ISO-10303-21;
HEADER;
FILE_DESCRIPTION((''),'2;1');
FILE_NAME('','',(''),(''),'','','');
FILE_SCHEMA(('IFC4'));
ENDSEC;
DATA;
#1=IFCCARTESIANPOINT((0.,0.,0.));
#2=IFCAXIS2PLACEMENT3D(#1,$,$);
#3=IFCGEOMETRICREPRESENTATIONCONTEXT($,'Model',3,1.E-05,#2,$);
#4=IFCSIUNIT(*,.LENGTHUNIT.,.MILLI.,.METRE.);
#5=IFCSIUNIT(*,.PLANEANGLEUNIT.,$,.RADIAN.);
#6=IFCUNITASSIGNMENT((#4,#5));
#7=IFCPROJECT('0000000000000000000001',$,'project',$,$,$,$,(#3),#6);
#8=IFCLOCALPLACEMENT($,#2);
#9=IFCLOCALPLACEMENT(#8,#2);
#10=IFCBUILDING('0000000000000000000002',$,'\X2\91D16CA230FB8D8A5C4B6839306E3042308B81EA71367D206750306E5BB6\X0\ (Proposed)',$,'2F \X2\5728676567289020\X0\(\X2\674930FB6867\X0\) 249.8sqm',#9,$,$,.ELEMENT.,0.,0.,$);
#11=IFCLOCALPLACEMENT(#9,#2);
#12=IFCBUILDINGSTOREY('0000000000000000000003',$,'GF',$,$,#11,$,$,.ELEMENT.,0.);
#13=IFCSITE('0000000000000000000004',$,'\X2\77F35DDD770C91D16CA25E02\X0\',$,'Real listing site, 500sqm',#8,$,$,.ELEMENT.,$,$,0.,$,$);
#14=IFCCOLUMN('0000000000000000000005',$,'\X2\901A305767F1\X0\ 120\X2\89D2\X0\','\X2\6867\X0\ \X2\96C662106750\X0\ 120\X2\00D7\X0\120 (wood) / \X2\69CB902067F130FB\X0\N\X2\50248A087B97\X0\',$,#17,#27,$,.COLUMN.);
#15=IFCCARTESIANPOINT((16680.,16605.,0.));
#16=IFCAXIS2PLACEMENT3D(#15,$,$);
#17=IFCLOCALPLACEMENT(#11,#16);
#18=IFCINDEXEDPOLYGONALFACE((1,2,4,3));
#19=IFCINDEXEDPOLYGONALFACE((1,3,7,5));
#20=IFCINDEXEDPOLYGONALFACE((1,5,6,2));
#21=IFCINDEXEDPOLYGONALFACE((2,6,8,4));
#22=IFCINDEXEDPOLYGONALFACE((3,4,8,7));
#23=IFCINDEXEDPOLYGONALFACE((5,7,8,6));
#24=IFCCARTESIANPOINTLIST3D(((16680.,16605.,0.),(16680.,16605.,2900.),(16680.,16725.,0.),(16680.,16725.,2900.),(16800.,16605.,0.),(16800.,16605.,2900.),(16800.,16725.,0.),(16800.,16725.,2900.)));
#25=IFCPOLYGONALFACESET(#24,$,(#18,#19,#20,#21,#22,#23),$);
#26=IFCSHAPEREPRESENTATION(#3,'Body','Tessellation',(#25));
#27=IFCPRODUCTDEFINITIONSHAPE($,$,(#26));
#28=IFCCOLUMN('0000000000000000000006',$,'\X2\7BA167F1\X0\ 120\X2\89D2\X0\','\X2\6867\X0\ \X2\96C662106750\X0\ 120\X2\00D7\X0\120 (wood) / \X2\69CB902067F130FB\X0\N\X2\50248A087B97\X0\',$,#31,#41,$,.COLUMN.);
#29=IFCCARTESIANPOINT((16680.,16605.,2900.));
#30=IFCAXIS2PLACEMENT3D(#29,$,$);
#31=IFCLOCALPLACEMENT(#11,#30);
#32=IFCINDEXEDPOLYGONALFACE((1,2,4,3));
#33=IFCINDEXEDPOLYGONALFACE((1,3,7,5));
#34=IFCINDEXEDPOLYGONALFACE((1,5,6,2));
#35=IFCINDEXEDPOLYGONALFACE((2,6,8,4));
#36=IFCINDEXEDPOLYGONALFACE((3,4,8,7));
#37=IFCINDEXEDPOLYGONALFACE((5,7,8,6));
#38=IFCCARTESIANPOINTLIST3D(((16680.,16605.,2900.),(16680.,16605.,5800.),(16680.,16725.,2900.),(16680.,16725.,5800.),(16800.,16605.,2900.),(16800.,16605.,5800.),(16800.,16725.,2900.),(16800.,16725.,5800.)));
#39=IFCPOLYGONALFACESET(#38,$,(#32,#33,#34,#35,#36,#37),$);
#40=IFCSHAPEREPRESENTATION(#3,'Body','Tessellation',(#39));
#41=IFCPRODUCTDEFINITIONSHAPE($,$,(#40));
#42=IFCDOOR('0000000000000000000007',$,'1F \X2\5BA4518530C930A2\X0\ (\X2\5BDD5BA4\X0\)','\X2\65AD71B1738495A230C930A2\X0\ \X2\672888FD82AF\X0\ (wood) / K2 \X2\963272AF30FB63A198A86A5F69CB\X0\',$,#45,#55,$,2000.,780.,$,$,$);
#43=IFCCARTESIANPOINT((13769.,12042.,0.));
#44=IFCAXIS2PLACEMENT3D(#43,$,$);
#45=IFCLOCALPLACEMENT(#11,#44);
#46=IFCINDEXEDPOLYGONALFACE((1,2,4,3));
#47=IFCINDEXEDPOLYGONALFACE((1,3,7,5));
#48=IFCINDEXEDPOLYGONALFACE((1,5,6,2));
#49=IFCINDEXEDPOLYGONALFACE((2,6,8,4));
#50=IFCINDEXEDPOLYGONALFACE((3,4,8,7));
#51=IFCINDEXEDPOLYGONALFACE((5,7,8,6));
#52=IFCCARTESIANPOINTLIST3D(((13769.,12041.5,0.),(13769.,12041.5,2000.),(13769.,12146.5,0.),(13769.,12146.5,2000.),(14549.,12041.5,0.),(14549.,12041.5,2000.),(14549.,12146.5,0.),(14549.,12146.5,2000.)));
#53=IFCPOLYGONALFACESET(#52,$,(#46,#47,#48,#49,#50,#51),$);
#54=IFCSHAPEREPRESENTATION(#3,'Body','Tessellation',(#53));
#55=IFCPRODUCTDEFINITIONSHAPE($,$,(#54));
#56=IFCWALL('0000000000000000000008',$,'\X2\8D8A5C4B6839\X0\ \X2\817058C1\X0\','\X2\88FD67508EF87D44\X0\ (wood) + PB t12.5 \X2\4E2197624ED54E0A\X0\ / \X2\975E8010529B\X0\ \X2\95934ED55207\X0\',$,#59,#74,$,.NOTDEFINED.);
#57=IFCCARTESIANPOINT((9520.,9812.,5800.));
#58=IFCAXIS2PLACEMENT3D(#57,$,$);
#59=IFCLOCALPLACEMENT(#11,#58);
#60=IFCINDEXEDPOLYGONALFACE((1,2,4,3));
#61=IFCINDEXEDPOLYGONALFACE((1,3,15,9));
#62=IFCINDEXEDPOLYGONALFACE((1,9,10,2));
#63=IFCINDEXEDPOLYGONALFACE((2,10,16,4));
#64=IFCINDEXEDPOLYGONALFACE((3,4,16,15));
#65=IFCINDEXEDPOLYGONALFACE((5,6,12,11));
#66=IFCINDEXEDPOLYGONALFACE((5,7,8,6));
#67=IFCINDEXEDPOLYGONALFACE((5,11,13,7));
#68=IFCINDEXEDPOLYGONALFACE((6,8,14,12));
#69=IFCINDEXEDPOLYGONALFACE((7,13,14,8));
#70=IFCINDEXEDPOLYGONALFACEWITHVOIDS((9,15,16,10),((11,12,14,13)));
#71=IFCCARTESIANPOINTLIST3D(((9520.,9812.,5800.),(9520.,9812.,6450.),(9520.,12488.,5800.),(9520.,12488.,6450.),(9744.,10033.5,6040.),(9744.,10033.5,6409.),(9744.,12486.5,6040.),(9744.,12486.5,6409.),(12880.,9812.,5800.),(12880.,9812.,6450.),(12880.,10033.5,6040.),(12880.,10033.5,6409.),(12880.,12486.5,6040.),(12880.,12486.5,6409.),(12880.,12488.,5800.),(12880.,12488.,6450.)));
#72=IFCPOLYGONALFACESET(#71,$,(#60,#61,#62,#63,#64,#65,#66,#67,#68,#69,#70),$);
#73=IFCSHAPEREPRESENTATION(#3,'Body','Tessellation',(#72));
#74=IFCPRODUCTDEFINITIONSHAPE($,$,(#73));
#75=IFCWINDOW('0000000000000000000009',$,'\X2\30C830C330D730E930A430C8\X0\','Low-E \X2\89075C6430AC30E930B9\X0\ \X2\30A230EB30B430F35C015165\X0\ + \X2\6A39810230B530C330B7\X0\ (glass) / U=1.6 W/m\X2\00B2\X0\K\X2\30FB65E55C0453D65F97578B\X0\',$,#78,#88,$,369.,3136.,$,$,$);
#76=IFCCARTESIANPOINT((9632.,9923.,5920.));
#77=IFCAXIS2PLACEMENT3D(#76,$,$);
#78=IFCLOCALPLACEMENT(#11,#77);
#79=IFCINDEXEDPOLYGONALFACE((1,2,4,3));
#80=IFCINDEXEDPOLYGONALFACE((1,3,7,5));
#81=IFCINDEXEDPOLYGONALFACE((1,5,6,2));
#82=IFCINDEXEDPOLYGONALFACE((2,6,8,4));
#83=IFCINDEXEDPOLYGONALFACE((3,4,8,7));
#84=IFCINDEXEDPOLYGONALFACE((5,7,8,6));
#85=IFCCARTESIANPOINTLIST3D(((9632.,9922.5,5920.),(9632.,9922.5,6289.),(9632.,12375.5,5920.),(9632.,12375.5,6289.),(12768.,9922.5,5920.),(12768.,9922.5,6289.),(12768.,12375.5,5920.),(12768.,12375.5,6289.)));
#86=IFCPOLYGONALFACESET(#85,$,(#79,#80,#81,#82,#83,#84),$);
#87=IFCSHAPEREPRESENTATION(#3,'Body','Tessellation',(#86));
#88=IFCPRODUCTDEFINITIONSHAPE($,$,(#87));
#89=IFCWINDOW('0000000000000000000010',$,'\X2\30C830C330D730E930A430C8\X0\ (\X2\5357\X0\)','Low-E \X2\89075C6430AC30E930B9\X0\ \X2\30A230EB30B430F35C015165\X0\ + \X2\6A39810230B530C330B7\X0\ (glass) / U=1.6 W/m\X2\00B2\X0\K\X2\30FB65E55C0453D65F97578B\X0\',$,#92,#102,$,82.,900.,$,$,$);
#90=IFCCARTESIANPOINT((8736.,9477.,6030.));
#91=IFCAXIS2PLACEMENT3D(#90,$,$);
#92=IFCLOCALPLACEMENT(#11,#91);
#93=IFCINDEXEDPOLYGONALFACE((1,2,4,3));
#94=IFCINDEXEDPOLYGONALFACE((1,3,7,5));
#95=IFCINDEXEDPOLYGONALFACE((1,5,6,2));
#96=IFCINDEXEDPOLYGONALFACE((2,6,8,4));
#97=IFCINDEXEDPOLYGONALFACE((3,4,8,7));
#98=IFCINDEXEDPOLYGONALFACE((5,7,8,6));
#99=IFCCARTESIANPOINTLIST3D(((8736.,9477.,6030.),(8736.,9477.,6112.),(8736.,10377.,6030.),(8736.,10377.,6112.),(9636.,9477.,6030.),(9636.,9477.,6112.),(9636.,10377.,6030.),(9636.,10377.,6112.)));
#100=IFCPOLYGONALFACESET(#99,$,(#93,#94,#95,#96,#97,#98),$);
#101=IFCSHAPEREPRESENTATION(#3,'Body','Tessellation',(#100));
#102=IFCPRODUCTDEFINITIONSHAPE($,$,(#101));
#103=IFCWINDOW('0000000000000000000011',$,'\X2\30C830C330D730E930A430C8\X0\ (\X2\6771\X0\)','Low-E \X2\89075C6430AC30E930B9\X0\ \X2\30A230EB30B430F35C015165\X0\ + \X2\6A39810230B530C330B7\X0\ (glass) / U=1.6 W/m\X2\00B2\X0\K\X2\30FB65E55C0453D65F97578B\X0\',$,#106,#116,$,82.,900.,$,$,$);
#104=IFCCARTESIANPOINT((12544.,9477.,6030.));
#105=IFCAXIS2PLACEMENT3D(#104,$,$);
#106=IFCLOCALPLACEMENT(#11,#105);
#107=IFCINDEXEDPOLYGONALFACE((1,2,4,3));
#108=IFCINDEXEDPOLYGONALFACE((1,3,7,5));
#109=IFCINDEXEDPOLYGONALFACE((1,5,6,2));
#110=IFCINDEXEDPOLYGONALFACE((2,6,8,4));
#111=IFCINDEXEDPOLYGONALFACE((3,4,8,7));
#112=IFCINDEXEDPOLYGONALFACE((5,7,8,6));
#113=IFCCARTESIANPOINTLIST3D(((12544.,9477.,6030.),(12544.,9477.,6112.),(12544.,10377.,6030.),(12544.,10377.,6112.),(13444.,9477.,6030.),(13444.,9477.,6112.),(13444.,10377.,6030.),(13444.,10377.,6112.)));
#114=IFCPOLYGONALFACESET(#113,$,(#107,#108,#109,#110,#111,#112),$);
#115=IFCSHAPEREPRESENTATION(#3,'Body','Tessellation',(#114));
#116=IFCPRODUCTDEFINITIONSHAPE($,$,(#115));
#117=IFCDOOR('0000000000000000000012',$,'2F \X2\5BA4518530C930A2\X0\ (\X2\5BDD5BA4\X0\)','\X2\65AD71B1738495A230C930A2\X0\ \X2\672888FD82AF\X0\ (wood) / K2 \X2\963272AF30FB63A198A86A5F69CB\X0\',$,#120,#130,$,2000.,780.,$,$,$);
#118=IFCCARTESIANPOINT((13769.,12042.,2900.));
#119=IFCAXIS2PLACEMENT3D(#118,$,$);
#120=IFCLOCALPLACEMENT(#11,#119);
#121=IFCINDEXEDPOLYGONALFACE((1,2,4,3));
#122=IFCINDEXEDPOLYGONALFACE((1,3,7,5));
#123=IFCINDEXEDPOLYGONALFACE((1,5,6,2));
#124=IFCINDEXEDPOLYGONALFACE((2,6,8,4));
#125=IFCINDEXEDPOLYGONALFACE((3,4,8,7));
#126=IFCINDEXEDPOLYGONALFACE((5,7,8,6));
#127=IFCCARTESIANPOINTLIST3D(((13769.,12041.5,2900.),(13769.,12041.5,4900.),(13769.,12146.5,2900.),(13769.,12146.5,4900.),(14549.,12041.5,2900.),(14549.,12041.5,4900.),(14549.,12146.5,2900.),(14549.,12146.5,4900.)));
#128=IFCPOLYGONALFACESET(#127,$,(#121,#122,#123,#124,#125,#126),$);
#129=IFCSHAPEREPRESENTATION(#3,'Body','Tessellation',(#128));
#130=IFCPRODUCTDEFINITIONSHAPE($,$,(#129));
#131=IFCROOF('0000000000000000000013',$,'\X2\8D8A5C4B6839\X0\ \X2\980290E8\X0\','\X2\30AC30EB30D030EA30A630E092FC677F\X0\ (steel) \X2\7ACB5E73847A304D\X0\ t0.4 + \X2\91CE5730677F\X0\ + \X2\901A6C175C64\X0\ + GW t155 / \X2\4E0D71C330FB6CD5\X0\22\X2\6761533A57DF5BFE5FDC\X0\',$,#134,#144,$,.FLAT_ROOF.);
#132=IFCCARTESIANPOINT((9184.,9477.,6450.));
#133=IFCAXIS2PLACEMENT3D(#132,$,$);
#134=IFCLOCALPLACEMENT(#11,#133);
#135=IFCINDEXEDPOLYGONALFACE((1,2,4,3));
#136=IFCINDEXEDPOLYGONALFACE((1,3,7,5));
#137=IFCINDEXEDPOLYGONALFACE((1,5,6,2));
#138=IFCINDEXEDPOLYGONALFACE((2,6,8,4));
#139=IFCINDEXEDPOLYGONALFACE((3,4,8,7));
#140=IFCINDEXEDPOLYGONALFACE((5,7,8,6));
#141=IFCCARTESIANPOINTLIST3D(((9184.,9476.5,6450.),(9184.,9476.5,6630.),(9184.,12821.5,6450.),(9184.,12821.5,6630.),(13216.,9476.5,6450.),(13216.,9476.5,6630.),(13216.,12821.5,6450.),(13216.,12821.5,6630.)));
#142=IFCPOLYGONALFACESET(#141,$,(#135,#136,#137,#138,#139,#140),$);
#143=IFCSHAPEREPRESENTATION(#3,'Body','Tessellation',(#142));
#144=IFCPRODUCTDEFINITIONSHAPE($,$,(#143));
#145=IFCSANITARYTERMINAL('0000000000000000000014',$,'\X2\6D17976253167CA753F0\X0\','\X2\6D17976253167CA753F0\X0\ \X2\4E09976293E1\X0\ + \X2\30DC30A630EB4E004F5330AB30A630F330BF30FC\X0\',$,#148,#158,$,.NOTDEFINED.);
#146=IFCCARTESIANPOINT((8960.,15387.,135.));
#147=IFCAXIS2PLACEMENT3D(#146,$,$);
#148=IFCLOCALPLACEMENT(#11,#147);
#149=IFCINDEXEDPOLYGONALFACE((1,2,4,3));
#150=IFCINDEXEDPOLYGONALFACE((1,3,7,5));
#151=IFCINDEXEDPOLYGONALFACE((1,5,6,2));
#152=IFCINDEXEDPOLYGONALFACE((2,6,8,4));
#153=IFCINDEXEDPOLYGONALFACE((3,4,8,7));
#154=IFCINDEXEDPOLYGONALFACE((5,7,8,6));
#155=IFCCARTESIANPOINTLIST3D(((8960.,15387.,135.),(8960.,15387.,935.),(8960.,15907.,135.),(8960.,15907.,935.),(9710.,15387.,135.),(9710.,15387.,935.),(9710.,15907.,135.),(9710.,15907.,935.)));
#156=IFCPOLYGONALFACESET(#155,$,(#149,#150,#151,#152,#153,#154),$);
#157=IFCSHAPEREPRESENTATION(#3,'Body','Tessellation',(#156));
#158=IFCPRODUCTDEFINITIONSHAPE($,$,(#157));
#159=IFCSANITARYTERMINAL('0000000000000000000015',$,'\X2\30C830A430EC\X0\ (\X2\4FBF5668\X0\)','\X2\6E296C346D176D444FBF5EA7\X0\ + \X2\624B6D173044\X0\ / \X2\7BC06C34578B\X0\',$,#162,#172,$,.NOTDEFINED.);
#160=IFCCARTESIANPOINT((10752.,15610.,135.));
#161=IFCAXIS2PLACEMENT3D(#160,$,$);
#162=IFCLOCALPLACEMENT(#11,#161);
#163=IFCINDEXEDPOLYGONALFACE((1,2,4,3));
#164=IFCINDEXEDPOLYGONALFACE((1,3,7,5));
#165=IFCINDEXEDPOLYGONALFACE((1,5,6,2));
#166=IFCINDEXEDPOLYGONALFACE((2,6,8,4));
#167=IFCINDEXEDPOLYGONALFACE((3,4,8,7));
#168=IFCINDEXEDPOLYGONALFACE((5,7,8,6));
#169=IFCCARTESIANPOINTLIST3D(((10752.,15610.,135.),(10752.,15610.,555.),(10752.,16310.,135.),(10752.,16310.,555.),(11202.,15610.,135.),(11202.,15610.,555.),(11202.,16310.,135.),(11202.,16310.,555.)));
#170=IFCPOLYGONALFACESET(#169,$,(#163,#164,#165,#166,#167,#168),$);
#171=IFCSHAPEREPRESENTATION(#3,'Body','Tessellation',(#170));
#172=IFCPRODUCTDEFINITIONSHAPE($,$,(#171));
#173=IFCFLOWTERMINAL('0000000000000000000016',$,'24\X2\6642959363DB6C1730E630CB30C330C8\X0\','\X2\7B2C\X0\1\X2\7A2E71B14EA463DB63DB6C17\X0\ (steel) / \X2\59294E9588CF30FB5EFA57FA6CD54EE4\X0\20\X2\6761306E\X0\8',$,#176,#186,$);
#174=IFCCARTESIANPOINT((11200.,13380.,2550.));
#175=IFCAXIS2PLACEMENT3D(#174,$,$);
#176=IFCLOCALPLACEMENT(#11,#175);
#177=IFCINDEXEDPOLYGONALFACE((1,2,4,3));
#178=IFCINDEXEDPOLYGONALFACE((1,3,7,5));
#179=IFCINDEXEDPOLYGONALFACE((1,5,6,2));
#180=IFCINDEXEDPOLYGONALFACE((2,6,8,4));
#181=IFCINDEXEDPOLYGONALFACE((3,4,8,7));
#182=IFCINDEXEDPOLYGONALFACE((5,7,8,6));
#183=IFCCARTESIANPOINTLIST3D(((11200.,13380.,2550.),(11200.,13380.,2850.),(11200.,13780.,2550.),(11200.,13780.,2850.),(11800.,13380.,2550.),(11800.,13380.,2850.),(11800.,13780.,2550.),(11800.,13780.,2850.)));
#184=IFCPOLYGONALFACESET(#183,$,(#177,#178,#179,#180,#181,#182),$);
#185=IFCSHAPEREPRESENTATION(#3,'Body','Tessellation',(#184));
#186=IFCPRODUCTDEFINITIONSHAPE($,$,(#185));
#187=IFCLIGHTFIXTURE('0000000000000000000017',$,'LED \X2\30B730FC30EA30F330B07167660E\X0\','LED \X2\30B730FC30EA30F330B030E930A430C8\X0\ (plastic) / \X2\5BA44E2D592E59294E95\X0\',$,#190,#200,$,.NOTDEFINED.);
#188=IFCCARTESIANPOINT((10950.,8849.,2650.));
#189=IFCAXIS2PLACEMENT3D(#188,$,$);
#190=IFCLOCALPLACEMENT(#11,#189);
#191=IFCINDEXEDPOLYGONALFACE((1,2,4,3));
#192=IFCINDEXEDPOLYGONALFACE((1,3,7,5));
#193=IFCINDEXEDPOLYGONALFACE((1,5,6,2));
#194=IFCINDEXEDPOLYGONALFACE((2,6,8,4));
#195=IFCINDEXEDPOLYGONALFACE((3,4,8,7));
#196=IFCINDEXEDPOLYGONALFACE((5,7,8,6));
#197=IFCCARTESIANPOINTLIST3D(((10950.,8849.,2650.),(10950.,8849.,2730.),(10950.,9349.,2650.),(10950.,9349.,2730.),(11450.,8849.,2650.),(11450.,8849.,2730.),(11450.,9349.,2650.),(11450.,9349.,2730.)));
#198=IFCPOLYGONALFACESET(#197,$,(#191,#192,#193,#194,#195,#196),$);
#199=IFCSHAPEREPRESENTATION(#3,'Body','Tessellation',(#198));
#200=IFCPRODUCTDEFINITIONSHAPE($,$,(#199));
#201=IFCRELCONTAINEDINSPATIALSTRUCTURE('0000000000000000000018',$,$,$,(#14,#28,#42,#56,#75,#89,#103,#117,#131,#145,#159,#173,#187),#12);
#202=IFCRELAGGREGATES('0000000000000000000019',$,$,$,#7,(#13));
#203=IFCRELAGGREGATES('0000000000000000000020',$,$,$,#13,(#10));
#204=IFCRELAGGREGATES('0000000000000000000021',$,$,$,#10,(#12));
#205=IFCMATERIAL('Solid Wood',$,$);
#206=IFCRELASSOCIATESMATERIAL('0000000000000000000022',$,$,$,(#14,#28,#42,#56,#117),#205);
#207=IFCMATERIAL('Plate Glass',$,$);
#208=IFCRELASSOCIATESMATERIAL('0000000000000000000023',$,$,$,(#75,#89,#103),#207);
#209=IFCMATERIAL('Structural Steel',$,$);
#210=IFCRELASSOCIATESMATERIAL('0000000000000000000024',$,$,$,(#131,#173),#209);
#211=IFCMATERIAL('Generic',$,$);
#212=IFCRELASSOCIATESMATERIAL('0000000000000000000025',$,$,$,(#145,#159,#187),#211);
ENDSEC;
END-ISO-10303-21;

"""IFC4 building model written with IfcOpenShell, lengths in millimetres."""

from ifc_helpers import new_model, si_unit, frame, frame_2d, origin, place, context, project, spatial, rectangle, extrude, material, element, fill, save


model = new_model("IFC4")

# Units and contexts
model_context = context("Model", 3, precision=1e-05, world=origin())
ifc_project = project(units=[si_unit("LENGTHUNIT", "METRE", prefix="MILLI"), si_unit("PLANEANGLEUNIT", "RADIAN")], contexts=[model_context])

# Site, building, storey
site_placement = place(None, origin())
site = spatial("IfcSite", under=ifc_project, at=site_placement, Name="石川県金沢市", ObjectType="Real listing site, 500sqm", CompositionType="ELEMENT", RefElevation=0.0)
building_placement = place(site_placement, origin())
building = spatial("IfcBuilding", under=site, at=building_placement, Name="金沢・越屋根のある自然素材の家 (Proposed)", ObjectType="2F 在来木造(杉・桧) 249.8sqm", CompositionType="ELEMENT", ElevationOfRefHeight=0.0, ElevationOfTerrain=0.0)
storey_placement = place(building_placement, origin())
storey = spatial("IfcBuildingStorey", under=building, at=storey_placement, Name="GF", CompositionType="ELEMENT", Elevation=0.0)

# Columns
ifc_material_1 = material(Name="Solid Wood")
column_1_placement = place(storey_placement, frame((16680.0, 16605.0, 0.0)))
element("IfcColumn", 1, at=column_1_placement, inside=storey, material=ifc_material_1, Name="通し柱 120角", Description="桧 集成材 120×120 (wood) / 構造柱・N値計算", PredefinedType="COLUMN", context=model_context, shape_type="SweptSolid", body=[
    extrude(rectangle(XDim=120.0, YDim=120.0, at=frame_2d((60.0, 60.0))), frame((16680.0, 16605.0, 0.0)), (0.0, 0.0, 1.0), 2900.0),
])
column_2_placement = place(storey_placement, frame((16680.0, 16605.0, 2900.0)))
element("IfcColumn", 2, at=column_2_placement, inside=storey, material=ifc_material_1, Name="管柱 120角", Description="桧 集成材 120×120 (wood) / 構造柱・N値計算", PredefinedType="COLUMN", context=model_context, shape_type="SweptSolid", body=[
    extrude(rectangle(XDim=120.0, YDim=120.0, at=frame_2d((60.0, 60.0))), frame((16680.0, 16605.0, 2900.0)), (0.0, 0.0, 1.0), 2900.0),
])

# Door
door_1_placement = place(storey_placement, frame((13769.0, 12042.0, 0.0)))
element("IfcDoor", 3, at=door_1_placement, inside=storey, material=ifc_material_1, Name="1F 室内ドア (寝室)", Description="断熱玄関ドア 木製芯 (wood) / K2 防犯・採風機構", OverallHeight=2000.0, OverallWidth=780.0, context=model_context, shape_type="SweptSolid", body=[
    extrude(rectangle(XDim=780.0, YDim=105.0, at=frame_2d((390.0, 52.0))), frame((13769.0, 12042.0, 0.0)), (0.0, 0.0, 1.0), 2000.0),
])

# Wall, openings, windows
wall_1_placement = place(storey_placement, frame((9520.0, 9812.0, 5800.0)))
wall_1 = element("IfcWall", 4, at=wall_1_placement, inside=storey, material=ifc_material_1, Name="越屋根 腰壁", Description="製材軸組 (wood) + PB t12.5 両面仕上 / 非耐力 間仕切", PredefinedType="NOTDEFINED", context=model_context, shape_type="SweptSolid", body=[
    extrude(rectangle(XDim=3360.0, YDim=2676.0, at=frame_2d((1680.0, 1338.0))), frame((9520.0, 9812.0, 5800.0)), (0.0, 0.0, 1.0), 650.0),
])
opening_1_placement = place(storey_placement, frame((9632.0, 9923.0, 5920.0)))
opening_1 = element("IfcOpeningElement", 5, at=opening_1_placement, cuts=wall_1, PredefinedType="NOTDEFINED", context=model_context, shape_type="SweptSolid", body=[
    extrude(rectangle(XDim=3136.0, YDim=2453.0, at=frame_2d((1568.0, 1226.0))), frame((9632.0, 9923.0, 5920.0)), (0.0, 0.0, 1.0), 369.0),
])
opening_2_placement = place(storey_placement, frame((8736.0, 9477.0, 6030.0)))
opening_2 = element("IfcOpeningElement", 6, at=opening_2_placement, cuts=wall_1, PredefinedType="NOTDEFINED", context=model_context, shape_type="SweptSolid", body=[
    extrude(rectangle(XDim=900.0, YDim=900.0, at=frame_2d((450.0, 450.0))), frame((8736.0, 9477.0, 6030.0)), (0.0, 0.0, 1.0), 82.0),
])
opening_3_placement = place(storey_placement, frame((12544.0, 9477.0, 6030.0)))
opening_3 = element("IfcOpeningElement", 7, at=opening_3_placement, cuts=wall_1, PredefinedType="NOTDEFINED", context=model_context, shape_type="SweptSolid", body=[
    extrude(rectangle(XDim=900.0, YDim=900.0, at=frame_2d((450.0, 450.0))), frame((12544.0, 9477.0, 6030.0)), (0.0, 0.0, 1.0), 82.0),
])
ifc_material_2 = material(Name="Plate Glass")
window_1_placement = place(storey_placement, frame((9632.0, 9923.0, 5920.0)))
window_1 = element("IfcWindow", 8, at=window_1_placement, inside=storey, material=ifc_material_2, Name="トップライト", Description="Low-E 複層ガラス アルゴン封入 + 樹脂サッシ (glass) / U=1.6 W/m²K・日射取得型", OverallHeight=369.0, OverallWidth=3136.0, context=model_context, shape_type="SweptSolid", body=[
    extrude(rectangle(XDim=3136.0, YDim=2453.0, at=frame_2d((1568.0, 1226.0))), frame((9632.0, 9923.0, 5920.0)), (0.0, 0.0, 1.0), 369.0),
])
fill(opening_1, window_1)
window_2_placement = place(storey_placement, frame((8736.0, 9477.0, 6030.0)))
window_2 = element("IfcWindow", 9, at=window_2_placement, inside=storey, material=ifc_material_2, Name="トップライト (南)", Description="Low-E 複層ガラス アルゴン封入 + 樹脂サッシ (glass) / U=1.6 W/m²K・日射取得型", OverallHeight=82.0, OverallWidth=900.0, context=model_context, shape_type="SweptSolid", body=[
    extrude(rectangle(XDim=900.0, YDim=900.0, at=frame_2d((450.0, 450.0))), frame((8736.0, 9477.0, 6030.0)), (0.0, 0.0, 1.0), 82.0),
])
fill(opening_2, window_2)
window_3_placement = place(storey_placement, frame((12544.0, 9477.0, 6030.0)))
window_3 = element("IfcWindow", 10, at=window_3_placement, inside=storey, material=ifc_material_2, Name="トップライト (東)", Description="Low-E 複層ガラス アルゴン封入 + 樹脂サッシ (glass) / U=1.6 W/m²K・日射取得型", OverallHeight=82.0, OverallWidth=900.0, context=model_context, shape_type="SweptSolid", body=[
    extrude(rectangle(XDim=900.0, YDim=900.0, at=frame_2d((450.0, 450.0))), frame((12544.0, 9477.0, 6030.0)), (0.0, 0.0, 1.0), 82.0),
])
fill(opening_3, window_3)

# Door
door_2_placement = place(storey_placement, frame((13769.0, 12042.0, 2900.0)))
element("IfcDoor", 11, at=door_2_placement, inside=storey, material=ifc_material_1, Name="2F 室内ドア (寝室)", Description="断熱玄関ドア 木製芯 (wood) / K2 防犯・採風機構", OverallHeight=2000.0, OverallWidth=780.0, context=model_context, shape_type="SweptSolid", body=[
    extrude(rectangle(XDim=780.0, YDim=105.0, at=frame_2d((390.0, 52.0))), frame((13769.0, 12042.0, 2900.0)), (0.0, 0.0, 1.0), 2000.0),
])

# Roof
ifc_material_3 = material(Name="Structural Steel")
roof_placement = place(storey_placement, frame((9184.0, 9477.0, 6450.0)))
element("IfcRoof", 12, at=roof_placement, inside=storey, material=ifc_material_3, Name="越屋根 頂部", Description="ガルバリウム鋼板 (steel) 立平葺き t0.4 + 野地板 + 通気層 + GW t155 / 不燃・法22条区域対応", PredefinedType="FLAT_ROOF", context=model_context, shape_type="SweptSolid", body=[
    extrude(rectangle(XDim=4032.0, YDim=3345.0, at=frame_2d((2016.0, 1672.0))), frame((9184.0, 9477.0, 6450.0)), (0.0, 0.0, 1.0), 180.0),
])

# Sanitary terminals
ifc_material_4 = material(Name="Generic")
sanitary_terminal_1_placement = place(storey_placement, frame((8960.0, 15387.0, 135.0)))
element("IfcSanitaryTerminal", 13, at=sanitary_terminal_1_placement, inside=storey, material=ifc_material_4, Name="洗面化粧台", Description="洗面化粧台 三面鏡 + ボウル一体カウンター", PredefinedType="NOTDEFINED", context=model_context, shape_type="SweptSolid", body=[
    extrude(rectangle(XDim=750.0, YDim=520.0, at=frame_2d((375.0, 260.0))), frame((8960.0, 15387.0, 135.0)), (0.0, 0.0, 1.0), 800.0),
])
sanitary_terminal_2_placement = place(storey_placement, frame((10752.0, 15610.0, 135.0)))
element("IfcSanitaryTerminal", 14, at=sanitary_terminal_2_placement, inside=storey, material=ifc_material_4, Name="トイレ (便器)", Description="温水洗浄便座 + 手洗い / 節水型", PredefinedType="NOTDEFINED", context=model_context, shape_type="SweptSolid", body=[
    extrude(rectangle(XDim=450.0, YDim=700.0, at=frame_2d((225.0, 350.0))), frame((10752.0, 15610.0, 135.0)), (0.0, 0.0, 1.0), 420.0),
])

# Flow terminal
flow_terminal_placement = place(storey_placement, frame((11200.0, 13380.0, 2550.0)))
element("IfcFlowTerminal", 15, at=flow_terminal_placement, inside=storey, material=ifc_material_3, Name="24時間換気ユニット", Description="第1種熱交換換気 (steel) / 天井裏・建基法令20条の8", context=model_context, shape_type="SweptSolid", body=[
    extrude(rectangle(XDim=600.0, YDim=400.0, at=frame_2d((300.0, 200.0))), frame((11200.0, 13380.0, 2550.0)), (0.0, 0.0, 1.0), 300.0),
])

# Light fixture
light_fixture_1_placement = place(storey_placement, frame((10950.0, 8849.0, 2650.0)))
element("IfcLightFixture", 16, at=light_fixture_1_placement, inside=storey, material=ifc_material_4, Name="LED シーリング照明", Description="LED シーリングライト (plastic) / 室中央天井", PredefinedType="NOTDEFINED", context=model_context, shape_type="SweptSolid", body=[
    extrude(rectangle(XDim=500.0, YDim=500.0, at=frame_2d((250.0, 250.0))), frame((10950.0, 8849.0, 2650.0)), (0.0, 0.0, 1.0), 80.0),
])

save(model, "model.ifc")
